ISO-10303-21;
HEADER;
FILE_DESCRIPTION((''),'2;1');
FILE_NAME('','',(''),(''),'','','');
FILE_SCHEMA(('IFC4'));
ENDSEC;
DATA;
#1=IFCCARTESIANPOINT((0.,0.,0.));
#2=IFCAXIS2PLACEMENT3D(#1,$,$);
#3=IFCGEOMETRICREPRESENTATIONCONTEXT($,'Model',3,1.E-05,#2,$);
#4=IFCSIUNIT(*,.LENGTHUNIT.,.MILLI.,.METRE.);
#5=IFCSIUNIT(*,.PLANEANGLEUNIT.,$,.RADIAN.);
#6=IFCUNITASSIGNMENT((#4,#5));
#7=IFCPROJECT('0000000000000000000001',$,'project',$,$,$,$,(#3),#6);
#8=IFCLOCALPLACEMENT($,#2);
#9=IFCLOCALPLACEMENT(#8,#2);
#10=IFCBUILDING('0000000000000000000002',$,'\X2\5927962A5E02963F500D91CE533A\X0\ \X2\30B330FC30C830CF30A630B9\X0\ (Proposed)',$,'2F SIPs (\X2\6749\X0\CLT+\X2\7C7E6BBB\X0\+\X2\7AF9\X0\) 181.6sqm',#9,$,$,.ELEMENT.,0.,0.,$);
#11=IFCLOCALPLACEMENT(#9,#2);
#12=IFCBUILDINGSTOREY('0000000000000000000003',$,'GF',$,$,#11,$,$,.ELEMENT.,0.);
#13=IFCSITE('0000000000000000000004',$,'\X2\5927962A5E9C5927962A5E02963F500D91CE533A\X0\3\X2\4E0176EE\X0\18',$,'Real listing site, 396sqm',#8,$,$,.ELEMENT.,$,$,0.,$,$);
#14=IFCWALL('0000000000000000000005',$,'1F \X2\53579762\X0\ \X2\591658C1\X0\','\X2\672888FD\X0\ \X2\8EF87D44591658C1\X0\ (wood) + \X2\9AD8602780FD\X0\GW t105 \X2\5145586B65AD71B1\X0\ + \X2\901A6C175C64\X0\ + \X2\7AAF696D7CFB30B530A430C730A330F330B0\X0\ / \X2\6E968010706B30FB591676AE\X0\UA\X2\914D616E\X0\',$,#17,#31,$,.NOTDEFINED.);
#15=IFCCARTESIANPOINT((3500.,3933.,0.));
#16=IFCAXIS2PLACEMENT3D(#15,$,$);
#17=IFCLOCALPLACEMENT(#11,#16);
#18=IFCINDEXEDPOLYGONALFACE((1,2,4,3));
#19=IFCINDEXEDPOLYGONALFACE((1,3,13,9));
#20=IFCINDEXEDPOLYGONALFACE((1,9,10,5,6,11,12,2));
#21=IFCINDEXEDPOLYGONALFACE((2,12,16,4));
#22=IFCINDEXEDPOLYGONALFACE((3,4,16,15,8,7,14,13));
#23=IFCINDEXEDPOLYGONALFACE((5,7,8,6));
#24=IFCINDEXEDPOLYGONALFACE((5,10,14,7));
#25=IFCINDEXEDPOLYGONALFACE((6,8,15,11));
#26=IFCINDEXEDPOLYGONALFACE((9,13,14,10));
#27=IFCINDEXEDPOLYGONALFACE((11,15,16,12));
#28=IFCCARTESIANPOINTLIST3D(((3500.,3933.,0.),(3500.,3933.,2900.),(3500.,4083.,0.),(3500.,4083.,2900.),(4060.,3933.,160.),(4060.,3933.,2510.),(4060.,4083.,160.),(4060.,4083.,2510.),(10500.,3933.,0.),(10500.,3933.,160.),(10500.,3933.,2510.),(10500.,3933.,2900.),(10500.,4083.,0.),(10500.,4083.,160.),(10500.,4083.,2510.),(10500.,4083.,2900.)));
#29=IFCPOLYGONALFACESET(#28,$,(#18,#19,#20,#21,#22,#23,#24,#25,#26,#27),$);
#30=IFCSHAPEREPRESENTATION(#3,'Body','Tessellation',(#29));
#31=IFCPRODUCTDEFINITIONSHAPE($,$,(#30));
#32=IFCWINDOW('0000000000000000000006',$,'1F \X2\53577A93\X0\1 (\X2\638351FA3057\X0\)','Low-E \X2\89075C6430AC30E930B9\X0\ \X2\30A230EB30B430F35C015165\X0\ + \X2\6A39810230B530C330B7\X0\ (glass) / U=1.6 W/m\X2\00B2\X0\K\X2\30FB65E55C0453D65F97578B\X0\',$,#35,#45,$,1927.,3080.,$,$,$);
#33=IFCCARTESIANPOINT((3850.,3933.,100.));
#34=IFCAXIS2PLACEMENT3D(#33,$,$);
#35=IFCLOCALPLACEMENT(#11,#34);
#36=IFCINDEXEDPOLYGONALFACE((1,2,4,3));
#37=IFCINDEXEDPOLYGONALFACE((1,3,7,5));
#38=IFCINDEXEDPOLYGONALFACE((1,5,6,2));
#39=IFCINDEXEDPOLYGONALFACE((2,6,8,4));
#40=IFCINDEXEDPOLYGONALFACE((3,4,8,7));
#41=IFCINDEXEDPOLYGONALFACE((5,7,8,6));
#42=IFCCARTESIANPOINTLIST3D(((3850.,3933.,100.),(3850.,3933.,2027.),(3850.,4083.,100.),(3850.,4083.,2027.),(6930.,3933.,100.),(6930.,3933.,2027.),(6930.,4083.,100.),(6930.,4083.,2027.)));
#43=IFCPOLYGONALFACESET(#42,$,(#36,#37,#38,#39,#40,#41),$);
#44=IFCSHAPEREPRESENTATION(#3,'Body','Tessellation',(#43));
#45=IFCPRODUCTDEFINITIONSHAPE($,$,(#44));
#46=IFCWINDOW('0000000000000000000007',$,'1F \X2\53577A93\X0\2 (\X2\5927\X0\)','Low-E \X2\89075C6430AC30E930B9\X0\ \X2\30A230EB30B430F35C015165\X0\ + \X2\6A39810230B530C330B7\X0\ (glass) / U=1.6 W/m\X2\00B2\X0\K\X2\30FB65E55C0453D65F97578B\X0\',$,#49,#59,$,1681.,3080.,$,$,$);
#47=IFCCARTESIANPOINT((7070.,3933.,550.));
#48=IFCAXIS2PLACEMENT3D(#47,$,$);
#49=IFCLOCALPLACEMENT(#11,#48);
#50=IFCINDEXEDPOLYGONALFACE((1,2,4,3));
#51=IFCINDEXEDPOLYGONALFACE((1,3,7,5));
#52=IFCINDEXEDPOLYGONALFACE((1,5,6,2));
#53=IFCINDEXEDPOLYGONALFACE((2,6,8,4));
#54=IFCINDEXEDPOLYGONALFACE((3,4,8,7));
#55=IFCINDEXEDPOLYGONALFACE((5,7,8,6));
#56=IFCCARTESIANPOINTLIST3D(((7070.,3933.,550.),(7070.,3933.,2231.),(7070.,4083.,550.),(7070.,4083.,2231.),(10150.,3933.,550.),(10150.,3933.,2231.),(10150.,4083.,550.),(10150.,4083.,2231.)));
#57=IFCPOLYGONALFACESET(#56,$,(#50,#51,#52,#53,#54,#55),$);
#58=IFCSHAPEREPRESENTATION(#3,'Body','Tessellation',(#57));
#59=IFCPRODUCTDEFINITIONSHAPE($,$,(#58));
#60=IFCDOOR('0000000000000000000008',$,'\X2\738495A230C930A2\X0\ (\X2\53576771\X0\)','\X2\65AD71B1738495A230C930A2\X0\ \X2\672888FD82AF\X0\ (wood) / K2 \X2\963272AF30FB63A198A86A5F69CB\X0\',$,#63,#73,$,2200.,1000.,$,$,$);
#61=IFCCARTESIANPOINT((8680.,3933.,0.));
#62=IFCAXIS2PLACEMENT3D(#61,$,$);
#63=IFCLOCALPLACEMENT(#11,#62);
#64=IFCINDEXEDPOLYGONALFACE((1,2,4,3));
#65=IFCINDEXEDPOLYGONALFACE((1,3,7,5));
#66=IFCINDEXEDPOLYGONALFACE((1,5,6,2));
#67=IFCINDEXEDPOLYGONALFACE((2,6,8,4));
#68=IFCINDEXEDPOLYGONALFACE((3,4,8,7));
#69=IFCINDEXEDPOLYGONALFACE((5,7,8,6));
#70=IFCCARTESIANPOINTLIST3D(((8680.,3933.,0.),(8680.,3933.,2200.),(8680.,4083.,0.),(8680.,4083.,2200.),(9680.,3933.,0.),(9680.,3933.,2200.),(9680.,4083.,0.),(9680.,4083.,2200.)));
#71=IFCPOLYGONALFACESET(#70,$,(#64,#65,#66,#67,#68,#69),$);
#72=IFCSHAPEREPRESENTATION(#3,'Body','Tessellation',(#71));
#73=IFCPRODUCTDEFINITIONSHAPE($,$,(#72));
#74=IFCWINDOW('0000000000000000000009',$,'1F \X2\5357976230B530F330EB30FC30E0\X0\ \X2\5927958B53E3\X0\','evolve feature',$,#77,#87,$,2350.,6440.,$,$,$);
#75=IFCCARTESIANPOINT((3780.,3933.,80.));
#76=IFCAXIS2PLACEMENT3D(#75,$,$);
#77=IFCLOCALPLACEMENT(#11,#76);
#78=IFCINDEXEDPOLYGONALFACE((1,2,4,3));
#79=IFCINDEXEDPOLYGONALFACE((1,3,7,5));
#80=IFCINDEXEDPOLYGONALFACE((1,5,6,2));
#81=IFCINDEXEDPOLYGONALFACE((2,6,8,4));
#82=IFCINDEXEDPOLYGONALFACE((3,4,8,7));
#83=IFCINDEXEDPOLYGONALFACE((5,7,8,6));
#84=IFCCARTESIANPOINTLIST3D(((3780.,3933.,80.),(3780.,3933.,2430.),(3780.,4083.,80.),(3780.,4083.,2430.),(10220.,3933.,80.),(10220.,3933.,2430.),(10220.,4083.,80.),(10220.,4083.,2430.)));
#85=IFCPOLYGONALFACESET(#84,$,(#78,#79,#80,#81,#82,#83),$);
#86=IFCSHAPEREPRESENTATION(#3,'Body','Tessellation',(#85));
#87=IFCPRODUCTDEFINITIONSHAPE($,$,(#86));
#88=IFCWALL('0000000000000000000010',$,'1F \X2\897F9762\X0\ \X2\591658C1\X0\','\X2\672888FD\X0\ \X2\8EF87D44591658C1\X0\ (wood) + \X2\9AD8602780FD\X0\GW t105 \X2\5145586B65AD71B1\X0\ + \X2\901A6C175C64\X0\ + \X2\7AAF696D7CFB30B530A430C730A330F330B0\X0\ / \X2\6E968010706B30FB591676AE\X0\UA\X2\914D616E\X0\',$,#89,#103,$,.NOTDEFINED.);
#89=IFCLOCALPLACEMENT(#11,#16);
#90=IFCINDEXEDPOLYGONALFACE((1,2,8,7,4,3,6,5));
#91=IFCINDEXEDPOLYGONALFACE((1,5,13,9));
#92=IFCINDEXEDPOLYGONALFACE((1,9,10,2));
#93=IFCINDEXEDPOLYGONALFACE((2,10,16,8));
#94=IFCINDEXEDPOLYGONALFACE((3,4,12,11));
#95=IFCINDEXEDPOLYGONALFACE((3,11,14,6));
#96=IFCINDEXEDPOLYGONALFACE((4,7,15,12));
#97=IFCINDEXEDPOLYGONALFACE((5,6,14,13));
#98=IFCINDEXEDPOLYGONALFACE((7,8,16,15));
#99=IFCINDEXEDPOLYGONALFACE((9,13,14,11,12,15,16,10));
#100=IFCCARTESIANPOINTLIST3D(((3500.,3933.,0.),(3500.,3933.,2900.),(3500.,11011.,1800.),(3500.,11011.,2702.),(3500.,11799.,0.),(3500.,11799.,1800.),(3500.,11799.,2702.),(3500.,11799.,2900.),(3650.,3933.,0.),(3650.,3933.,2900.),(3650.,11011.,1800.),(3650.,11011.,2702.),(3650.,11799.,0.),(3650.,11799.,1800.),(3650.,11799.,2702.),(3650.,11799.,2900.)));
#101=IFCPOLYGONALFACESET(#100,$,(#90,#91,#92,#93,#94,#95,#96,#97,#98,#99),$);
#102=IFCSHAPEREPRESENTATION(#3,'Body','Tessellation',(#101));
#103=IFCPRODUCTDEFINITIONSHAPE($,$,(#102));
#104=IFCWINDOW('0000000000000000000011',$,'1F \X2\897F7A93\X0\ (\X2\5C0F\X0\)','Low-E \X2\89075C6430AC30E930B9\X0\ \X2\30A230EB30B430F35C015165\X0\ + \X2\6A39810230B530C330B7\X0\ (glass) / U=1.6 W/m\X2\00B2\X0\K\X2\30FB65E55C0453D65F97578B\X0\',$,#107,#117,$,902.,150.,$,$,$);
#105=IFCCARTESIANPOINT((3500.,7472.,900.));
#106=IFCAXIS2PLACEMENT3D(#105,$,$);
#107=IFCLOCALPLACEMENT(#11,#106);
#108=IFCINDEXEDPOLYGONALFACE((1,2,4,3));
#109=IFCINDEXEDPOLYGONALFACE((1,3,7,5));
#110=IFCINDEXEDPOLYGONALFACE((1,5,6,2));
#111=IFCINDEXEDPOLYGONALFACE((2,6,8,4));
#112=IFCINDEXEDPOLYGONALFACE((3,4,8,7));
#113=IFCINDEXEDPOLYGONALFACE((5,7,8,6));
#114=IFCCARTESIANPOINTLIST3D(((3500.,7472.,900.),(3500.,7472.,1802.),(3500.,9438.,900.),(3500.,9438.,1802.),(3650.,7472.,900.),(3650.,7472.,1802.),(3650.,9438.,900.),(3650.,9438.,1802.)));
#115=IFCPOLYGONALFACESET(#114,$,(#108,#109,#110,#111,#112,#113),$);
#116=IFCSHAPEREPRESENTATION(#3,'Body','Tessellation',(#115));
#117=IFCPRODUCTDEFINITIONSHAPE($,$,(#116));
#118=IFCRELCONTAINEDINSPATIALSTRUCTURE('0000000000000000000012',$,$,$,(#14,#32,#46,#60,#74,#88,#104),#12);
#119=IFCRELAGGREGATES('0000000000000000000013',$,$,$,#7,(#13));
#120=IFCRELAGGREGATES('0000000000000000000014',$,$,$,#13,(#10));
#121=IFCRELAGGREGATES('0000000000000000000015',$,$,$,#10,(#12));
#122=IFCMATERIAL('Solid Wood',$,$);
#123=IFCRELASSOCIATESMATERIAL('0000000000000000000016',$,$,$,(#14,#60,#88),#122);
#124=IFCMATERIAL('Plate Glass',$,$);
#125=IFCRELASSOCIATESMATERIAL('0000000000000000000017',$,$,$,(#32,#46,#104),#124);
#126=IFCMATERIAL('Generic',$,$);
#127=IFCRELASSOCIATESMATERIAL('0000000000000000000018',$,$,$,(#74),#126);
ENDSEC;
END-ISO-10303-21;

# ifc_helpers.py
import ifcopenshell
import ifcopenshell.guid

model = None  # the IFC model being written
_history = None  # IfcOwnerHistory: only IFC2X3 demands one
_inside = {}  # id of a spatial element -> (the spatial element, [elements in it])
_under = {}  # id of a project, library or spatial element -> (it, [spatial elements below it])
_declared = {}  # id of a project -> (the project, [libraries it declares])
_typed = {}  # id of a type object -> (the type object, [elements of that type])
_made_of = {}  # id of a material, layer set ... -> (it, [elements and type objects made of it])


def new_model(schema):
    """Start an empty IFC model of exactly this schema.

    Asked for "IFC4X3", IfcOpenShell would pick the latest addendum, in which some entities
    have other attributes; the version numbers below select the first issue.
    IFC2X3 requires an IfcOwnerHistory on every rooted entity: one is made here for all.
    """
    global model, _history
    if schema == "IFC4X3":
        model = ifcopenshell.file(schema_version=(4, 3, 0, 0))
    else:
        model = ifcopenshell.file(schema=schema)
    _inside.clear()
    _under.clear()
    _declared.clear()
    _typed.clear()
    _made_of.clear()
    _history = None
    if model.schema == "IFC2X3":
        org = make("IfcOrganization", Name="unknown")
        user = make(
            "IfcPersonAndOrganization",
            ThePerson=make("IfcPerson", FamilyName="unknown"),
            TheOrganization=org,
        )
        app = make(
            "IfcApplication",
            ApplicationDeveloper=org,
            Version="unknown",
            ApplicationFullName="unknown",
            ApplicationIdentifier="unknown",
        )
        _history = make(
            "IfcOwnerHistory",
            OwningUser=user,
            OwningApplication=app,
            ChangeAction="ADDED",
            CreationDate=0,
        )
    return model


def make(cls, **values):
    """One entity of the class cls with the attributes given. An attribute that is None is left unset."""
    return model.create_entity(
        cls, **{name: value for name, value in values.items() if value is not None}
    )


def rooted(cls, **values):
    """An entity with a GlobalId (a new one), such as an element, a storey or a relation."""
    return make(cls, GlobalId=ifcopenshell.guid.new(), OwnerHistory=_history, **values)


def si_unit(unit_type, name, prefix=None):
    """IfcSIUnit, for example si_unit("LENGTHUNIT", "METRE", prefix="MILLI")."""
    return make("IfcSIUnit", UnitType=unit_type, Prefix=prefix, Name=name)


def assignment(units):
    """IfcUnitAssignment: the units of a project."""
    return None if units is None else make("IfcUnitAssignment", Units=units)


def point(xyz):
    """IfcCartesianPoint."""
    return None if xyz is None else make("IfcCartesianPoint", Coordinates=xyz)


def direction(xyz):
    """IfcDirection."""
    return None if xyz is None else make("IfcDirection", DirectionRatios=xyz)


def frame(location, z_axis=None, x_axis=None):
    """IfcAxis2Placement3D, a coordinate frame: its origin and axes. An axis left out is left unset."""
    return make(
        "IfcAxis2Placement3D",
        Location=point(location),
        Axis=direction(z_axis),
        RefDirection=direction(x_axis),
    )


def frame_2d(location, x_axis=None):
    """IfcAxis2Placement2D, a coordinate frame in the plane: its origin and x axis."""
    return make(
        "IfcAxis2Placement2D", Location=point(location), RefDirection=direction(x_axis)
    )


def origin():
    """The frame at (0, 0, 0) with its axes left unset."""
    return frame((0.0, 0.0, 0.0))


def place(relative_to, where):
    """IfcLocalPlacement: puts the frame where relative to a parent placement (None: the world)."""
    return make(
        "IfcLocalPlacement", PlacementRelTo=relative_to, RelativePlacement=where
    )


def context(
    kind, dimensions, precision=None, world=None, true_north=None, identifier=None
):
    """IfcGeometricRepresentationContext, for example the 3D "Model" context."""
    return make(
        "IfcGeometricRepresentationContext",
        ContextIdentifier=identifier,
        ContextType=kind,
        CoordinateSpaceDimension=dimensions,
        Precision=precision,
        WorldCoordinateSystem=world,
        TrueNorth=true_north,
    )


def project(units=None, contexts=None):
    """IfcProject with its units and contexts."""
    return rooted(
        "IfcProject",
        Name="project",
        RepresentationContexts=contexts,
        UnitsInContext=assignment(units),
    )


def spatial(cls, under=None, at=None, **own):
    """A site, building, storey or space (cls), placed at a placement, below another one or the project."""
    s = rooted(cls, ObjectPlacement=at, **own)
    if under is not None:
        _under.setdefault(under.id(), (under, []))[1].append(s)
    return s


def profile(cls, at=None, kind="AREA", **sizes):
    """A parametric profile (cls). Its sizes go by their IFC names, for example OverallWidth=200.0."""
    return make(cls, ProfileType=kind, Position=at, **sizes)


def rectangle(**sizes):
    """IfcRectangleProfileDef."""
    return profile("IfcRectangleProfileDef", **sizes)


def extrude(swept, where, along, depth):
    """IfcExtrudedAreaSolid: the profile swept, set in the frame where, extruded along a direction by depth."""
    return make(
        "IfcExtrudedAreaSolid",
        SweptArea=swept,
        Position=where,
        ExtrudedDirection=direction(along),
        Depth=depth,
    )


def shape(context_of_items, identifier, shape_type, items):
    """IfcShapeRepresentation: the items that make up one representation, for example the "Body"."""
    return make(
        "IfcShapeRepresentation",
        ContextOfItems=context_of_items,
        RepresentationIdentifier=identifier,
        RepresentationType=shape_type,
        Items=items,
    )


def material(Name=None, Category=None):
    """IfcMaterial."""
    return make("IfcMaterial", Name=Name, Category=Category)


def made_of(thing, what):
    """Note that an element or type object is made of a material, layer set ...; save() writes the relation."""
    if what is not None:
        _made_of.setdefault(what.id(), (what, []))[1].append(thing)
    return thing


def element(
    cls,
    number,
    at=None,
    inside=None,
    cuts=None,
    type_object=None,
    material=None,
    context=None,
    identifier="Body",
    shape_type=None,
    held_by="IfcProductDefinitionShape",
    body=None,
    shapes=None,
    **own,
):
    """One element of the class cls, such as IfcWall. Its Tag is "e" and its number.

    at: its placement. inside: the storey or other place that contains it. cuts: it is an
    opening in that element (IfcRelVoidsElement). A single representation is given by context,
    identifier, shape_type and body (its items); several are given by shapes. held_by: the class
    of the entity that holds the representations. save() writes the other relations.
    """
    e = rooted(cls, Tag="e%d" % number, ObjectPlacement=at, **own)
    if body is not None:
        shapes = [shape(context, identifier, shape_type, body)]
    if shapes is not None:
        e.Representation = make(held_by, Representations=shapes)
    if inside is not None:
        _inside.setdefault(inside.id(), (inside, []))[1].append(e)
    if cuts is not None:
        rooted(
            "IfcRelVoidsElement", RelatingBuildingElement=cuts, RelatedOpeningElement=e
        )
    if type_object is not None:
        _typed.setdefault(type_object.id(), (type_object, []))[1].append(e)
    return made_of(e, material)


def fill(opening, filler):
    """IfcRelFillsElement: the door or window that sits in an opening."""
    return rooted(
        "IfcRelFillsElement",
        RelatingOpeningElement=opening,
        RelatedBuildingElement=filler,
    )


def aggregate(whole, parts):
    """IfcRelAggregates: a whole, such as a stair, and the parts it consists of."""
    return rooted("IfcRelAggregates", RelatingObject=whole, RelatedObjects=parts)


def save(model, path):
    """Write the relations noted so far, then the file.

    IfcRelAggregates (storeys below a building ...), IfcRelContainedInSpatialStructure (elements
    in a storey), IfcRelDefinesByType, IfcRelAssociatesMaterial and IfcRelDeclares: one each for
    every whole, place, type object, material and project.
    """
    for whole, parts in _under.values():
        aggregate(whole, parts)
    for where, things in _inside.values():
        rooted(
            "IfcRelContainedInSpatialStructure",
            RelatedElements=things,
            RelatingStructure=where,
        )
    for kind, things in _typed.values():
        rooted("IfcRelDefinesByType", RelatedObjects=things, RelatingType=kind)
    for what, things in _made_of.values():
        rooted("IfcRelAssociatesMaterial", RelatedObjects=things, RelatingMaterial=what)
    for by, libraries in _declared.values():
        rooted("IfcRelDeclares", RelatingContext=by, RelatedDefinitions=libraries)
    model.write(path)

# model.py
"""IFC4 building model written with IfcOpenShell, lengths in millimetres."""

from ifc_helpers import new_model, si_unit, frame, frame_2d, origin, place, context, project, spatial, rectangle, extrude, material, element, fill, save


model = new_model("IFC4")

# Units and contexts
model_context = context("Model", 3, precision=1e-05, world=origin())
ifc_project = project(units=[si_unit("LENGTHUNIT", "METRE", prefix="MILLI"), si_unit("PLANEANGLEUNIT", "RADIAN")], contexts=[model_context])

# Site, building, storey
site_placement = place(None, origin())
site = spatial("IfcSite", under=ifc_project, at=site_placement, Name="大阪府大阪市阿倍野区3丁目18", ObjectType="Real listing site, 396sqm", CompositionType="ELEMENT", RefElevation=0.0)
building_placement = place(site_placement, origin())
building = spatial("IfcBuilding", under=site, at=building_placement, Name="大阪市阿倍野区 コートハウス (Proposed)", ObjectType="2F SIPs (杉CLT+籾殻+竹) 181.6sqm", CompositionType="ELEMENT", ElevationOfRefHeight=0.0, ElevationOfTerrain=0.0)
storey_placement = place(building_placement, origin())
storey = spatial("IfcBuildingStorey", under=building, at=storey_placement, Name="GF", CompositionType="ELEMENT", Elevation=0.0)

# Shared definitions
ifc_material_1 = material(Name="Solid Wood")
ifc_material_2 = material(Name="Generic")

# Wall, openings, windows, door
wall_1_placement = place(storey_placement, frame((3500.0, 3933.0, 0.0)))
wall_1 = element("IfcWall", 1, at=wall_1_placement, inside=storey, material=ifc_material_1, Name="1F 南面 外壁", Description="木製 軸組外壁 (wood) + 高性能GW t105 充填断熱 + 通気層 + 窯業系サイディング / 準耐火・外皮UA配慮", PredefinedType="NOTDEFINED", context=model_context, shape_type="SweptSolid", body=[
    extrude(rectangle(XDim=7000.0, YDim=150.0, at=frame_2d((3500.0, 75.0))), frame((3500.0, 3933.0, 0.0)), (0.0, 0.0, 1.0), 2900.0),
])
opening_1_placement = place(storey_placement, frame((3850.0, 3933.0, 100.0)))
opening_1 = element("IfcOpeningElement", 2, at=opening_1_placement, cuts=wall_1, PredefinedType="NOTDEFINED", context=model_context, shape_type="SweptSolid", body=[
    extrude(rectangle(XDim=3080.0, YDim=150.0, at=frame_2d((1540.0, 75.0))), frame((3850.0, 3933.0, 100.0)), (0.0, 0.0, 1.0), 1927.0),
])
opening_2_placement = place(storey_placement, frame((7070.0, 3933.0, 550.0)))
opening_2 = element("IfcOpeningElement", 3, at=opening_2_placement, cuts=wall_1, PredefinedType="NOTDEFINED", context=model_context, shape_type="SweptSolid", body=[
    extrude(rectangle(XDim=3080.0, YDim=150.0, at=frame_2d((1540.0, 75.0))), frame((7070.0, 3933.0, 550.0)), (0.0, 0.0, 1.0), 1681.0),
])
opening_3_placement = place(storey_placement, frame((8680.0, 3933.0, 0.0)))
opening_3 = element("IfcOpeningElement", 4, at=opening_3_placement, cuts=wall_1, PredefinedType="NOTDEFINED", context=model_context, shape_type="SweptSolid", body=[
    extrude(rectangle(XDim=1000.0, YDim=150.0, at=frame_2d((500.0, 75.0))), frame((8680.0, 3933.0, 0.0)), (0.0, 0.0, 1.0), 2200.0),
])
opening_4_placement = place(storey_placement, frame((3780.0, 3933.0, 80.0)))
opening_4 = element("IfcOpeningElement", 5, at=opening_4_placement, cuts=wall_1, PredefinedType="NOTDEFINED", context=model_context, shape_type="SweptSolid", body=[
    extrude(rectangle(XDim=6440.0, YDim=150.0, at=frame_2d((3220.0, 75.0))), frame((3780.0, 3933.0, 80.0)), (0.0, 0.0, 1.0), 2350.0),
])
ifc_material_3 = material(Name="Plate Glass")
window_1_placement = place(storey_placement, frame((3850.0, 3933.0, 100.0)))
window_1 = element("IfcWindow", 6, at=window_1_placement, inside=storey, material=ifc_material_3, Name="1F 南窓1 (掃出し)", Description="Low-E 複層ガラス アルゴン封入 + 樹脂サッシ (glass) / U=1.6 W/m²K・日射取得型", OverallHeight=1927.0, OverallWidth=3080.0, context=model_context, shape_type="SweptSolid", body=[
    extrude(rectangle(XDim=3080.0, YDim=150.0, at=frame_2d((1540.0, 75.0))), frame((3850.0, 3933.0, 100.0)), (0.0, 0.0, 1.0), 1927.0),
])
fill(opening_1, window_1)
window_2_placement = place(storey_placement, frame((7070.0, 3933.0, 550.0)))
window_2 = element("IfcWindow", 7, at=window_2_placement, inside=storey, material=ifc_material_3, Name="1F 南窓2 (大)", Description="Low-E 複層ガラス アルゴン封入 + 樹脂サッシ (glass) / U=1.6 W/m²K・日射取得型", OverallHeight=1681.0, OverallWidth=3080.0, context=model_context, shape_type="SweptSolid", body=[
    extrude(rectangle(XDim=3080.0, YDim=150.0, at=frame_2d((1540.0, 75.0))), frame((7070.0, 3933.0, 550.0)), (0.0, 0.0, 1.0), 1681.0),
])
fill(opening_2, window_2)
door_placement = place(storey_placement, frame((8680.0, 3933.0, 0.0)))
door = element("IfcDoor", 8, at=door_placement, inside=storey, material=ifc_material_1, Name="玄関ドア (南東)", Description="断熱玄関ドア 木製芯 (wood) / K2 防犯・採風機構", OverallHeight=2200.0, OverallWidth=1000.0, context=model_context, shape_type="SweptSolid", body=[
    extrude(rectangle(XDim=1000.0, YDim=150.0, at=frame_2d((500.0, 75.0))), frame((8680.0, 3933.0, 0.0)), (0.0, 0.0, 1.0), 2200.0),
])
fill(opening_3, door)
window_3_placement = place(storey_placement, frame((3780.0, 3933.0, 80.0)))
window_3 = element("IfcWindow", 9, at=window_3_placement, inside=storey, material=ifc_material_2, Name="1F 南面サンルーム 大開口", Description="evolve feature", OverallHeight=2350.0, OverallWidth=6440.0, context=model_context, shape_type="SweptSolid", body=[
    extrude(rectangle(XDim=6440.0, YDim=150.0, at=frame_2d((3220.0, 75.0))), frame((3780.0, 3933.0, 80.0)), (0.0, 0.0, 1.0), 2350.0),
])
fill(opening_4, window_3)

# Wall, opening, window
wall_2_placement = place(storey_placement, frame((3500.0, 3933.0, 0.0)))
wall_2 = element("IfcWall", 10, at=wall_2_placement, inside=storey, material=ifc_material_1, Name="1F 西面 外壁", Description="木製 軸組外壁 (wood) + 高性能GW t105 充填断熱 + 通気層 + 窯業系サイディング / 準耐火・外皮UA配慮", PredefinedType="NOTDEFINED", context=model_context, shape_type="SweptSolid", body=[
    extrude(rectangle(XDim=150.0, YDim=7866.0, at=frame_2d((75.0, 3933.0))), frame((3500.0, 3933.0, 0.0)), (0.0, 0.0, 1.0), 2900.0),
])
opening_5_placement = place(storey_placement, frame((3500.0, 7472.0, 900.0)))
opening_5 = element("IfcOpeningElement", 11, at=opening_5_placement, cuts=wall_2, PredefinedType="NOTDEFINED", context=model_context, shape_type="SweptSolid", body=[
    extrude(rectangle(XDim=150.0, YDim=1966.0, at=frame_2d((75.0, 983.0))), frame((3500.0, 7472.0, 900.0)), (0.0, 0.0, 1.0), 902.0),
])
window_4_placement = place(storey_placement, frame((3500.0, 7472.0, 900.0)))
window_4 = element("IfcWindow", 12, at=window_4_placement, inside=storey, material=ifc_material_3, Name="1F 西窓 (小)", Description="Low-E 複層ガラス アルゴン封入 + 樹脂サッシ (glass) / U=1.6 W/m²K・日射取得型", OverallHeight=902.0, OverallWidth=150.0, context=model_context, shape_type="SweptSolid", body=[
    extrude(rectangle(XDim=150.0, YDim=1966.0, at=frame_2d((75.0, 983.0))), frame((3500.0, 7472.0, 900.0)), (0.0, 0.0, 1.0), 902.0),
])
fill(opening_5, window_4)

save(model, "model.ifc")
